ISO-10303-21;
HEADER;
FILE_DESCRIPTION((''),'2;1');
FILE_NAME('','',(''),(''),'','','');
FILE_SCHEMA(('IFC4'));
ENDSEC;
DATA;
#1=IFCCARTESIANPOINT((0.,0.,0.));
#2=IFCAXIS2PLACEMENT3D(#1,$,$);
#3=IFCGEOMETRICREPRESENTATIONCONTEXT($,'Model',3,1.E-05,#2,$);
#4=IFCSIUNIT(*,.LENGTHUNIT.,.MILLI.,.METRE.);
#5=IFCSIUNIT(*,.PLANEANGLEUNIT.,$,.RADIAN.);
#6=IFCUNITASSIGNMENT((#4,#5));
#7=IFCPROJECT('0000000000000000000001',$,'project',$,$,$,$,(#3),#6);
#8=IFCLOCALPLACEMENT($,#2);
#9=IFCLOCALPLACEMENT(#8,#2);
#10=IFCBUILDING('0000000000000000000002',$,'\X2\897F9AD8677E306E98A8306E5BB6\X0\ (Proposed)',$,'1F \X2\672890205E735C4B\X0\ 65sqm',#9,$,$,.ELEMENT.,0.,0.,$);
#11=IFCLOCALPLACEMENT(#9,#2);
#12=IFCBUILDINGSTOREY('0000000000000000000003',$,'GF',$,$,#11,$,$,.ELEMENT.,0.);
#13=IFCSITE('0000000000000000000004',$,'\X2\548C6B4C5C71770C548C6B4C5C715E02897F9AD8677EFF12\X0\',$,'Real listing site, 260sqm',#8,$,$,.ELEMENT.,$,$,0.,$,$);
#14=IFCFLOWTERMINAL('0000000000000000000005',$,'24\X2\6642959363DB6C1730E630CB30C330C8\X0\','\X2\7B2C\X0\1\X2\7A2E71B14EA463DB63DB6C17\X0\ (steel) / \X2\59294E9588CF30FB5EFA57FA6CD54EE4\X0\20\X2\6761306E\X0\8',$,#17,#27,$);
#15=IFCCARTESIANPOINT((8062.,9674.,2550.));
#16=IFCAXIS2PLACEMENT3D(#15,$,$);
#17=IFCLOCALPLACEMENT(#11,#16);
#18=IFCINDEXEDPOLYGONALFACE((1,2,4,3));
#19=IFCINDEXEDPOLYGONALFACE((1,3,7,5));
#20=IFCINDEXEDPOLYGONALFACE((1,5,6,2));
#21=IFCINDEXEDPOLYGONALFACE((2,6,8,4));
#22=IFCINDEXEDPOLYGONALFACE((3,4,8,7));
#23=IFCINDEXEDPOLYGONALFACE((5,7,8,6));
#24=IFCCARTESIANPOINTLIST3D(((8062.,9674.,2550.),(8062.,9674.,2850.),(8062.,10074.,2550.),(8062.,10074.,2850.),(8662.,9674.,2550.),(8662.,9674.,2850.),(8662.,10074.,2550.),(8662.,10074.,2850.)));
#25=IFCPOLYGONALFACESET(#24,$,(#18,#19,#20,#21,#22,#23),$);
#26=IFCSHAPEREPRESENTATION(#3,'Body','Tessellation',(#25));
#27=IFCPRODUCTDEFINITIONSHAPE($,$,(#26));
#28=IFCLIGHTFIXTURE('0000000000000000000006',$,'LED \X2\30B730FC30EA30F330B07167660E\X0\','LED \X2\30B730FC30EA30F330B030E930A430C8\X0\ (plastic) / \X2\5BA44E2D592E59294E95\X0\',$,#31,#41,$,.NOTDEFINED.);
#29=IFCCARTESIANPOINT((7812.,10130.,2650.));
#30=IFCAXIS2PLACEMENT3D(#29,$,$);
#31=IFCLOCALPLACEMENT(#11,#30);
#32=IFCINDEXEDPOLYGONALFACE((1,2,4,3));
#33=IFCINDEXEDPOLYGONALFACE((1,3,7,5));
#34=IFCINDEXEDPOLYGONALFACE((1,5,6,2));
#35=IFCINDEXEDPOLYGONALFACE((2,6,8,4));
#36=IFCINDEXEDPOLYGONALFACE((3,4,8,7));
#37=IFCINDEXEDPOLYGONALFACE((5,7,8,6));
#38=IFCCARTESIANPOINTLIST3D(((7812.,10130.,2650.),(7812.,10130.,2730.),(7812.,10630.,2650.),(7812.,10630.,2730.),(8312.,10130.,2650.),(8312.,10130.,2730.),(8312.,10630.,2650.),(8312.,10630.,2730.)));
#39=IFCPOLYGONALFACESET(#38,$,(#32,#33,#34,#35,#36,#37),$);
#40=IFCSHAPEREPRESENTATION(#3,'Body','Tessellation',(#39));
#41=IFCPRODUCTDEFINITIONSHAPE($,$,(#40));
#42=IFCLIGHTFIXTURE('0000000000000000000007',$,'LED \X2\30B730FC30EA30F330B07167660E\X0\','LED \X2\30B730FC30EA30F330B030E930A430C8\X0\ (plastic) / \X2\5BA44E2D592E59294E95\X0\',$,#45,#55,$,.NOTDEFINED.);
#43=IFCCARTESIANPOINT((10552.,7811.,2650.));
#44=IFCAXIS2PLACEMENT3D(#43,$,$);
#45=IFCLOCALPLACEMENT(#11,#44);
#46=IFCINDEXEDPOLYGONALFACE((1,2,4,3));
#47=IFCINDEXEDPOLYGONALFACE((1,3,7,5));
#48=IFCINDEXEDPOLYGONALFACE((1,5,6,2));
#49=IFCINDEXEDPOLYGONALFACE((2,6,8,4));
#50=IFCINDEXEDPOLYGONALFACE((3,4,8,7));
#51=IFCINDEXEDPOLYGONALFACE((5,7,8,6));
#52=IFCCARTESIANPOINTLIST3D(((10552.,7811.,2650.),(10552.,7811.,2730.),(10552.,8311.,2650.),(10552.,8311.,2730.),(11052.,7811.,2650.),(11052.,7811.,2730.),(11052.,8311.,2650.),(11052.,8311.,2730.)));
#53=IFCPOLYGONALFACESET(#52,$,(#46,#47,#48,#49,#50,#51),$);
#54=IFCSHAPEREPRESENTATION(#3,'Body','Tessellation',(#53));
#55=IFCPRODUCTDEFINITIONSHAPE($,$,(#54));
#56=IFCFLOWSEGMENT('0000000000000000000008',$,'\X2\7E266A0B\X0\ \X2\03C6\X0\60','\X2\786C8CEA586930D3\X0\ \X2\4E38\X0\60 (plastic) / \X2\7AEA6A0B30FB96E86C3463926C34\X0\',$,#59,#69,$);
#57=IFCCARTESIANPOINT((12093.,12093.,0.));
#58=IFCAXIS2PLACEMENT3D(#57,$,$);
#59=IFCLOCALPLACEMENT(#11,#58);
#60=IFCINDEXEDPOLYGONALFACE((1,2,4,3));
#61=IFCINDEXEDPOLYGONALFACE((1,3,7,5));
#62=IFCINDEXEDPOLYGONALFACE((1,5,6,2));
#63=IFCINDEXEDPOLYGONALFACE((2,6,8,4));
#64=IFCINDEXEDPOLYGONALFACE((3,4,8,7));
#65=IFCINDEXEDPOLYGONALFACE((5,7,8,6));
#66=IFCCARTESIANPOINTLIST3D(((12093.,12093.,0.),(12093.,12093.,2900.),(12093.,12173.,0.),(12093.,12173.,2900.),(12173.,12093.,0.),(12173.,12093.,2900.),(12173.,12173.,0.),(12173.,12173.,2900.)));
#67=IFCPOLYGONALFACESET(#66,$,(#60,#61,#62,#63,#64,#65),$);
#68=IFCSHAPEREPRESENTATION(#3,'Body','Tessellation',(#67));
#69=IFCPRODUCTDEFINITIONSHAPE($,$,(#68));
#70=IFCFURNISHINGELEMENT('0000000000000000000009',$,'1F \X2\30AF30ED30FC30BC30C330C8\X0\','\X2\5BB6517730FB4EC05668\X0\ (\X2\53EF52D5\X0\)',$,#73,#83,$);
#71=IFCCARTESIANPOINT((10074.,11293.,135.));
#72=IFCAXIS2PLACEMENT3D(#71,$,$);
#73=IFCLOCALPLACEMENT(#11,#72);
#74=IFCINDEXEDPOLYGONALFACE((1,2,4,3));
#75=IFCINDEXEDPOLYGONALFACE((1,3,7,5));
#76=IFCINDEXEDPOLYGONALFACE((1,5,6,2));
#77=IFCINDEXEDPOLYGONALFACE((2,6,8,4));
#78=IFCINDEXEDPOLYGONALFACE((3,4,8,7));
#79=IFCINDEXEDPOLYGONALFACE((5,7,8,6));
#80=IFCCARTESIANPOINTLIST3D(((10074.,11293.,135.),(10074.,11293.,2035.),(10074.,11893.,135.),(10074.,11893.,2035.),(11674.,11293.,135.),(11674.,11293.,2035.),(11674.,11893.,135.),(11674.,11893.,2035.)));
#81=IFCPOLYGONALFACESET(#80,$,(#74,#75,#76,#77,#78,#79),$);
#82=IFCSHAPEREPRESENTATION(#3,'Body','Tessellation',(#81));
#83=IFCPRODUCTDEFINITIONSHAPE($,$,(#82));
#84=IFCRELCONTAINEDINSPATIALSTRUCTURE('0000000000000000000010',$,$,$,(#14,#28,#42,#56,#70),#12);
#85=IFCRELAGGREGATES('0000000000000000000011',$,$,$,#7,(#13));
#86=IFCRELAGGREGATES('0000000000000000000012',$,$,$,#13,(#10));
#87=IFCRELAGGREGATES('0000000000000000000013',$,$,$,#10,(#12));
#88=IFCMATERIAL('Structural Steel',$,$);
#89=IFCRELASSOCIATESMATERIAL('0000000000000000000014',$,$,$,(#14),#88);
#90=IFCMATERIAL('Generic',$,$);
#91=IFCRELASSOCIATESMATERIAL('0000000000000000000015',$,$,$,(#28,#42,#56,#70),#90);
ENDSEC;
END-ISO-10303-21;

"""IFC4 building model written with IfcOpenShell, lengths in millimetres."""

from ifc_helpers import new_model, si_unit, frame, frame_2d, origin, place, context, project, spatial, rectangle, extrude, material, element, save


model = new_model("IFC4")

# Units and contexts
model_context = context("Model", 3, precision=1e-05, world=origin())
ifc_project = project(units=[si_unit("LENGTHUNIT", "METRE", prefix="MILLI"), si_unit("PLANEANGLEUNIT", "RADIAN")], contexts=[model_context])

# Site, building, storey
site_placement = place(None, origin())
site = spatial("IfcSite", under=ifc_project, at=site_placement, Name="和歌山県和歌山市西高松２", ObjectType="Real listing site, 260sqm", CompositionType="ELEMENT", RefElevation=0.0)
building_placement = place(site_placement, origin())
building = spatial("IfcBuilding", under=site, at=building_placement, Name="西高松の風の家 (Proposed)", ObjectType="1F 木造平屋 65sqm", CompositionType="ELEMENT", ElevationOfRefHeight=0.0, ElevationOfTerrain=0.0)
storey_placement = place(building_placement, origin())
storey = spatial("IfcBuildingStorey", under=building, at=storey_placement, Name="GF", CompositionType="ELEMENT", Elevation=0.0)

# Shared definitions
ifc_material_1 = material(Name="Generic")

# Flow terminal
ifc_material_2 = material(Name="Structural Steel")
flow_terminal_placement = place(storey_placement, frame((8062.0, 9674.0, 2550.0)))
element("IfcFlowTerminal", 1, at=flow_terminal_placement, inside=storey, material=ifc_material_2, Name="24時間換気ユニット", Description="第1種熱交換換気 (steel) / 天井裏・建基法令20条の8", context=model_context, shape_type="SweptSolid", body=[
    extrude(rectangle(XDim=600.0, YDim=400.0, at=frame_2d((300.0, 200.0))), frame((8062.0, 9674.0, 2550.0)), (0.0, 0.0, 1.0), 300.0),
])

# Light fixtures
light_fixture_1_placement = place(storey_placement, frame((7812.0, 10130.0, 2650.0)))
element("IfcLightFixture", 2, at=light_fixture_1_placement, inside=storey, material=ifc_material_1, Name="LED シーリング照明", Description="LED シーリングライト (plastic) / 室中央天井", PredefinedType="NOTDEFINED", context=model_context, shape_type="SweptSolid", body=[
    extrude(rectangle(XDim=500.0, YDim=500.0, at=frame_2d((250.0, 250.0))), frame((7812.0, 10130.0, 2650.0)), (0.0, 0.0, 1.0), 80.0),
])
light_fixture_2_placement = place(storey_placement, frame((10552.0, 7811.0, 2650.0)))
element("IfcLightFixture", 3, at=light_fixture_2_placement, inside=storey, material=ifc_material_1, Name="LED シーリング照明", Description="LED シーリングライト (plastic) / 室中央天井", PredefinedType="NOTDEFINED", context=model_context, shape_type="SweptSolid", body=[
    extrude(rectangle(XDim=500.0, YDim=500.0, at=frame_2d((250.0, 250.0))), frame((10552.0, 7811.0, 2650.0)), (0.0, 0.0, 1.0), 80.0),
])

# Flow segment
flow_segment_placement = place(storey_placement, frame((12093.0, 12093.0, 0.0)))
element("IfcFlowSegment", 4, at=flow_segment_placement, inside=storey, material=ifc_material_1, Name="縦樋 φ60", Description="硬質塩ビ 丸60 (plastic) / 竪樋・雨水排水", context=model_context, shape_type="SweptSolid", body=[
    extrude(rectangle(XDim=80.0, YDim=80.0, at=frame_2d((40.0, 40.0))), frame((12093.0, 12093.0, 0.0)), (0.0, 0.0, 1.0), 2900.0),
])

# Furnishing element
furnishing_placement = place(storey_placement, frame((10074.0, 11293.0, 135.0)))
element("IfcFurnishingElement", 5, at=furnishing_placement, inside=storey, material=ifc_material_1, Name="1F クローゼット", Description="家具・什器 (可動)", context=model_context, shape_type="SweptSolid", body=[
    extrude(rectangle(XDim=1600.0, YDim=600.0, at=frame_2d((800.0, 300.0))), frame((10074.0, 11293.0, 135.0)), (0.0, 0.0, 1.0), 1900.0),
])

save(model, "model.ifc")
